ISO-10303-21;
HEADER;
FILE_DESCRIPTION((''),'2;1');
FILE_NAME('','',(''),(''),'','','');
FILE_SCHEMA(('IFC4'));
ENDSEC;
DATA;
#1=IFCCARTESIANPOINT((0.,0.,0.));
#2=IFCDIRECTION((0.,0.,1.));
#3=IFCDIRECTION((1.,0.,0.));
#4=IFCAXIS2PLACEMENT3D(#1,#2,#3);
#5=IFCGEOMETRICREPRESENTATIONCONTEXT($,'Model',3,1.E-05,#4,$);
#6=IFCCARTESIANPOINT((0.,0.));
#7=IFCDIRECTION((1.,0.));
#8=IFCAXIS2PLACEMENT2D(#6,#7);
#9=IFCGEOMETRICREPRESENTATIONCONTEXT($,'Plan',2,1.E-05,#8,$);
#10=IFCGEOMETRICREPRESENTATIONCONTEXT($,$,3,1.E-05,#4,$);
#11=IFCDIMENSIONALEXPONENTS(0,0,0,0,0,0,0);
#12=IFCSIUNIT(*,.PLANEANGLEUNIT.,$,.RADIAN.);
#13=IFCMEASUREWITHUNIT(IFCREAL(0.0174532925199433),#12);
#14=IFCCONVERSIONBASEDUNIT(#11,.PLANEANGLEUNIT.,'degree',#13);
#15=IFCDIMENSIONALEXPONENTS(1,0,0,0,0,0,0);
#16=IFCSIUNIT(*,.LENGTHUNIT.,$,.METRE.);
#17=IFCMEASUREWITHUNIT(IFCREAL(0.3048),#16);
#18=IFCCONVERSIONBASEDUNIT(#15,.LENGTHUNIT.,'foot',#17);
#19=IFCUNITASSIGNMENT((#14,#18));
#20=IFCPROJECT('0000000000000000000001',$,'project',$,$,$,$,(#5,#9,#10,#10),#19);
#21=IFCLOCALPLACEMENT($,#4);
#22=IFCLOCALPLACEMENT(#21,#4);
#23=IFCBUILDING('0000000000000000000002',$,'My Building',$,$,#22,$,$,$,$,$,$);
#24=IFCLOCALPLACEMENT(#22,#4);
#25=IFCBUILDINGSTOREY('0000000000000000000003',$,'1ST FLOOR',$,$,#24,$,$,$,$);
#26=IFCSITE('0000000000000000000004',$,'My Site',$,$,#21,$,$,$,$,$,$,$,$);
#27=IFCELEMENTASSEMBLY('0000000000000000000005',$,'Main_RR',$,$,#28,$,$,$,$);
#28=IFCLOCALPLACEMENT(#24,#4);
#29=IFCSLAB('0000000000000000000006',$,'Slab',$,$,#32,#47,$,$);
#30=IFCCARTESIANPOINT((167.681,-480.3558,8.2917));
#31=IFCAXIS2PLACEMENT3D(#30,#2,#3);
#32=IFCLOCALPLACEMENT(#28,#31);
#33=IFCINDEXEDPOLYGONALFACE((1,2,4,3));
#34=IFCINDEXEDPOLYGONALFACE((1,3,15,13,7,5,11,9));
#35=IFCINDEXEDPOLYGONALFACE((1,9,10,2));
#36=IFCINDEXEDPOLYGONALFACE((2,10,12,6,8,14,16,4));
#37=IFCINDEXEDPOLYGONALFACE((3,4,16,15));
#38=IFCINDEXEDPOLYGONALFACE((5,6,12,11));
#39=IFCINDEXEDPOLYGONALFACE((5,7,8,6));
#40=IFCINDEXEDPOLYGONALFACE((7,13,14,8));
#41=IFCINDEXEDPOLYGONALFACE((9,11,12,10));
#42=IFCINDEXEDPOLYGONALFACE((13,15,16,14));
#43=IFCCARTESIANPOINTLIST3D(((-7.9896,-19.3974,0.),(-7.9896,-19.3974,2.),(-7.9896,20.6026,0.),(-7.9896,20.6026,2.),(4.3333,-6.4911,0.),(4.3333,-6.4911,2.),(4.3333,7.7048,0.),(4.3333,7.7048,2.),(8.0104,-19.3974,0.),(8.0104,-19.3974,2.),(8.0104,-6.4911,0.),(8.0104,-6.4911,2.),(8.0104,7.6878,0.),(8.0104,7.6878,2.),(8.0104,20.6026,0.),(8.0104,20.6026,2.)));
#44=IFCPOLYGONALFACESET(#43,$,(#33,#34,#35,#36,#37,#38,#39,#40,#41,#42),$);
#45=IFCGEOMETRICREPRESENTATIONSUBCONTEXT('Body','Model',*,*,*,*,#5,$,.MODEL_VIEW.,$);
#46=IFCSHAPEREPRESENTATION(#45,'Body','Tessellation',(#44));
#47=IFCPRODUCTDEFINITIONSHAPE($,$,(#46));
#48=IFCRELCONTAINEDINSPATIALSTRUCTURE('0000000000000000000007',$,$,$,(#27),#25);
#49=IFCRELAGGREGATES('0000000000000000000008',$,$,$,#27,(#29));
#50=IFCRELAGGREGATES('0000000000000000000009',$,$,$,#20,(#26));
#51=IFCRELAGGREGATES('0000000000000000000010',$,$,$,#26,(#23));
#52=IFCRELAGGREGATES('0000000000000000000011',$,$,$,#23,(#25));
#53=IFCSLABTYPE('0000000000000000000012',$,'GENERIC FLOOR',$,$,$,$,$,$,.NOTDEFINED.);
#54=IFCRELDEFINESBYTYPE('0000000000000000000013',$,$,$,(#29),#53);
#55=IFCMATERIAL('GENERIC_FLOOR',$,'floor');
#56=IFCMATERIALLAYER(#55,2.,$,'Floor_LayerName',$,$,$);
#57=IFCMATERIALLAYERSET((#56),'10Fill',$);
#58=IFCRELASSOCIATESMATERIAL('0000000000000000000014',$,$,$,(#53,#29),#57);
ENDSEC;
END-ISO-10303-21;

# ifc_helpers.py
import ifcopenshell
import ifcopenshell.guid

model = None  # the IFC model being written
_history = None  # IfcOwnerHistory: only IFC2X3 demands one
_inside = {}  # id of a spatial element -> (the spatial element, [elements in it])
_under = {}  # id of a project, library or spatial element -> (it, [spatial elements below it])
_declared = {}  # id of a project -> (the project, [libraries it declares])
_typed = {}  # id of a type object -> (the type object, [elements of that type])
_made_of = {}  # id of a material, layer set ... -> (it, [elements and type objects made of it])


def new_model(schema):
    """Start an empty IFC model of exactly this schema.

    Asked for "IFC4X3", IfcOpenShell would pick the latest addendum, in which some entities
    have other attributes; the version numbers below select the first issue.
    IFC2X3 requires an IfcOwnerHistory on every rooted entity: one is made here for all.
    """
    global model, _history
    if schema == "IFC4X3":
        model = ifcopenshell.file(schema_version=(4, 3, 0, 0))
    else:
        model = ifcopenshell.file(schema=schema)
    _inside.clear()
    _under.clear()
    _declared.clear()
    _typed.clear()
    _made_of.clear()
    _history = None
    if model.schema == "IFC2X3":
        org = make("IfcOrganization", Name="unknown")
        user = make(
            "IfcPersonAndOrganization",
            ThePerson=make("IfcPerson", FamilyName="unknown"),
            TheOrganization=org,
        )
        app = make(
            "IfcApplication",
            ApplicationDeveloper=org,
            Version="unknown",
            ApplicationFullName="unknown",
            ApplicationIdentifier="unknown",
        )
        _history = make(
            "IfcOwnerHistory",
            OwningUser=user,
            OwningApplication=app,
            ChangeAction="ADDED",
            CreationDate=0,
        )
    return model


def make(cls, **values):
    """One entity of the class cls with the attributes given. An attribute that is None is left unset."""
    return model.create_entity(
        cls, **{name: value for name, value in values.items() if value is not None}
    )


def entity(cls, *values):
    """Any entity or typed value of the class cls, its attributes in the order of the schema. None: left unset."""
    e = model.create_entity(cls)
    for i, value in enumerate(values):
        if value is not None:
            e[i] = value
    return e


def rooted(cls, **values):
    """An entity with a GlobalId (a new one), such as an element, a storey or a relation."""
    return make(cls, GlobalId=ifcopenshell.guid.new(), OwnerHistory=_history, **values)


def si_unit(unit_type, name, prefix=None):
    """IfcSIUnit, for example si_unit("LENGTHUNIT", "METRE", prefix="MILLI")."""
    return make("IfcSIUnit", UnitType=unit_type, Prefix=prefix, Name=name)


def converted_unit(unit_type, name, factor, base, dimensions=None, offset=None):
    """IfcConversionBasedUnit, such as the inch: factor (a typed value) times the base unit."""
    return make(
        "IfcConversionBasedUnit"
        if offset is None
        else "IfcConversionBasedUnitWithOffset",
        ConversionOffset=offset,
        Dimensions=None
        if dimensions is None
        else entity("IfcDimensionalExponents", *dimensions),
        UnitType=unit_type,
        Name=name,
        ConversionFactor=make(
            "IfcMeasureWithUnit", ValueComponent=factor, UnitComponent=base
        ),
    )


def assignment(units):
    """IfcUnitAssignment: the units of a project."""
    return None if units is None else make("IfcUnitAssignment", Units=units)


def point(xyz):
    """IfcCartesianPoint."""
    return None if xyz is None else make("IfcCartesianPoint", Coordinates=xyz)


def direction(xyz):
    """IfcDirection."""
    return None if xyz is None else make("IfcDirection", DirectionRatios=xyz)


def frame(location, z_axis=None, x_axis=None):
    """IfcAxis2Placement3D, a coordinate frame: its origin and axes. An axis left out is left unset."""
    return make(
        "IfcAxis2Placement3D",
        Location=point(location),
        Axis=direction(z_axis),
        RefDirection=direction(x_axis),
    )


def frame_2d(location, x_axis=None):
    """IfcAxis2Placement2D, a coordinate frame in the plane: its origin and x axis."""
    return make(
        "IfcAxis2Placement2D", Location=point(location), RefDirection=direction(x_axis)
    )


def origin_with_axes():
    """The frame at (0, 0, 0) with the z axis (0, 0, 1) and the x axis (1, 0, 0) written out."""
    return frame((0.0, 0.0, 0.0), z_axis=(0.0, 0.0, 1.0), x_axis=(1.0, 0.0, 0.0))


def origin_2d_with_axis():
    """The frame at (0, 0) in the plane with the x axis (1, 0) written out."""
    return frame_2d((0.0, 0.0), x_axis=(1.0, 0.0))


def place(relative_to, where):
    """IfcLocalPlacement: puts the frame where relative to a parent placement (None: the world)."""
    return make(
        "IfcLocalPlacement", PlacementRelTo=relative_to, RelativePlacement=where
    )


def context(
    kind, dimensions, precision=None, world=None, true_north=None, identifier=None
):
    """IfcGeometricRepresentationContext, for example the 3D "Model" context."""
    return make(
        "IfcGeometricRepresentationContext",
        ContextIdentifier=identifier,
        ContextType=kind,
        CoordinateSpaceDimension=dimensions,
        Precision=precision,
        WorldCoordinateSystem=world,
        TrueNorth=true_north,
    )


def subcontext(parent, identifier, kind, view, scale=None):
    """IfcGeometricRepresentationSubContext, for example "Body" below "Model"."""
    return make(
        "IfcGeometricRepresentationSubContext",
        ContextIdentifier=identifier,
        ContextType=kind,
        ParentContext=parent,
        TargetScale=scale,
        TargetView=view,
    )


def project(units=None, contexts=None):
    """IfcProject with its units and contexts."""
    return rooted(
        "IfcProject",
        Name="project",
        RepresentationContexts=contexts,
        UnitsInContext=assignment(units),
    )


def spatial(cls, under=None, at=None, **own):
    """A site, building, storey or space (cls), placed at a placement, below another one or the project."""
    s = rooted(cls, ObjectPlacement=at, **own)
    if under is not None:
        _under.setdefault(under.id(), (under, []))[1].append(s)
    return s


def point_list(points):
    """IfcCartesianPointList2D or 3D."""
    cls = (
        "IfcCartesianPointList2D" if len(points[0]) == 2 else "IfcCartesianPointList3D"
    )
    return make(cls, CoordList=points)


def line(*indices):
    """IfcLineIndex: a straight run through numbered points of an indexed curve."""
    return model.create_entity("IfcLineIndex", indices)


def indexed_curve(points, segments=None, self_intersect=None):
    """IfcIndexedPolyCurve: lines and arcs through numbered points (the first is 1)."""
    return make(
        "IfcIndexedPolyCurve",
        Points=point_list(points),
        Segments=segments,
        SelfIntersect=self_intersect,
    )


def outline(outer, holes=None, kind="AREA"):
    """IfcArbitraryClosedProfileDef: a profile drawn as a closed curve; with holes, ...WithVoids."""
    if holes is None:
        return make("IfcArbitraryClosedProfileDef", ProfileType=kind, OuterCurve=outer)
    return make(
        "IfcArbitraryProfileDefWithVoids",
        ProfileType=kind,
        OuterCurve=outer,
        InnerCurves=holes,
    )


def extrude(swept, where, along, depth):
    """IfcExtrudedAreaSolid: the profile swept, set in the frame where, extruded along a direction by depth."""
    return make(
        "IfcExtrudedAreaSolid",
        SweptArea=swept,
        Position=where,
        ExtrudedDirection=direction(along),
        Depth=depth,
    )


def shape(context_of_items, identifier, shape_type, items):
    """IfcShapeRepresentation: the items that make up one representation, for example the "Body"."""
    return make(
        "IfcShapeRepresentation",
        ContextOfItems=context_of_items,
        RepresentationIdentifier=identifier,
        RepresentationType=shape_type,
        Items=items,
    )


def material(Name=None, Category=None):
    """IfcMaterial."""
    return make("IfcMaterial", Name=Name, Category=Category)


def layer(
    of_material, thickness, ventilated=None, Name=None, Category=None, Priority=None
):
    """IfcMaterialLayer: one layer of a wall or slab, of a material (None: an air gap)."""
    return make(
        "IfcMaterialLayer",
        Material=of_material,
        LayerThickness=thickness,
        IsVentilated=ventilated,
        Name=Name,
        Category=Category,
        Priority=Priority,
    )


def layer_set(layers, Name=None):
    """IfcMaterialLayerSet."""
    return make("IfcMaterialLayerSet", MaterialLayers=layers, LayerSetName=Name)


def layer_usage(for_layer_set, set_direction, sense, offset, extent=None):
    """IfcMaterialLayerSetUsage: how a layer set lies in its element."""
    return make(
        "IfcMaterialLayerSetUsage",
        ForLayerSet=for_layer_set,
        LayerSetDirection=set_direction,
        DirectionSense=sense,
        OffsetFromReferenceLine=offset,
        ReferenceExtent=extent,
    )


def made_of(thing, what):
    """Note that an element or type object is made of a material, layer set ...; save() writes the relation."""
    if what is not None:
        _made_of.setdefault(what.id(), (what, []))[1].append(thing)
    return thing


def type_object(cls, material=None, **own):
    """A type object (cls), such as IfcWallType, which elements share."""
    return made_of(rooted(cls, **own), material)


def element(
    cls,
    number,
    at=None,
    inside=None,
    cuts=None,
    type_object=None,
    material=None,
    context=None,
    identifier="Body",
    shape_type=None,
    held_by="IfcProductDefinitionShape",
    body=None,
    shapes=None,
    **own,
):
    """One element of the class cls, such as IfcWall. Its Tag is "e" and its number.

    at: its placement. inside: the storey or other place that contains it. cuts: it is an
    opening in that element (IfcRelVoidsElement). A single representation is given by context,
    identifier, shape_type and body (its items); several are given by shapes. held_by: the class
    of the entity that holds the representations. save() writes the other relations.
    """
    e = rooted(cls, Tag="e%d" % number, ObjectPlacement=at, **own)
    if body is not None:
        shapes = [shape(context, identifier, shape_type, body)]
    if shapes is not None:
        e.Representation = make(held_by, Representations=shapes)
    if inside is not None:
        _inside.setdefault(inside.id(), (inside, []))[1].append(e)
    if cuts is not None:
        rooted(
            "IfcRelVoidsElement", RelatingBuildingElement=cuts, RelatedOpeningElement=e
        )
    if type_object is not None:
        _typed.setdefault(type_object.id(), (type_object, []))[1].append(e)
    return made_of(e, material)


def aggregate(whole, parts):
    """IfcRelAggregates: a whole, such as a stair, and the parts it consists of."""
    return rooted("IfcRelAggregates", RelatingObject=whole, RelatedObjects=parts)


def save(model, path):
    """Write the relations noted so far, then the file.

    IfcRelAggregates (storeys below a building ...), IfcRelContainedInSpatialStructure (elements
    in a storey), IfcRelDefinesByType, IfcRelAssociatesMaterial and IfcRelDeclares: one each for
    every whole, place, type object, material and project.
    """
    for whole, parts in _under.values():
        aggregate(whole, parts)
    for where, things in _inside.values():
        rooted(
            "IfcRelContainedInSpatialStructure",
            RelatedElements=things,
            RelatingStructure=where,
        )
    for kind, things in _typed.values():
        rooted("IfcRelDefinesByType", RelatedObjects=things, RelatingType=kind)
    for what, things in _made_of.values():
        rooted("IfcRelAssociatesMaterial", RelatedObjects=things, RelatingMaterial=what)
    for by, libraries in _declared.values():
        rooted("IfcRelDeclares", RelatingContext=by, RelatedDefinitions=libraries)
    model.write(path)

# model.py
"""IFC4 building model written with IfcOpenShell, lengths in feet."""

from ifc_helpers import new_model, entity, si_unit, converted_unit, frame, origin_with_axes, origin_2d_with_axis, place, context, subcontext, project, spatial, line, indexed_curve, outline, extrude, material, layer, layer_set, layer_usage, type_object, element, aggregate, save


model = new_model("IFC4")

# Units and contexts
model_context = context("Model", 3, precision=1e-05, world=origin_with_axes())
plan_context = context("Plan", 2, precision=1e-05, world=origin_2d_with_axis())
context_of_model = context(None, 3, precision=1e-05, world=origin_with_axes())
body_context_1 = subcontext(model_context, "Body", "Model", "MODEL_VIEW")
ifc_project = project(units=[converted_unit("PLANEANGLEUNIT", "degree", entity("IfcReal", 0.0174532925199433), si_unit("PLANEANGLEUNIT", "RADIAN"), dimensions=[0, 0, 0, 0, 0, 0, 0]), converted_unit("LENGTHUNIT", "foot", entity("IfcReal", 0.3048), si_unit("LENGTHUNIT", "METRE"), dimensions=[1, 0, 0, 0, 0, 0, 0])], contexts=[model_context, plan_context, context_of_model, context_of_model])

# Site, building, storey
site_placement = place(None, origin_with_axes())
site = spatial("IfcSite", under=ifc_project, at=site_placement, Name="My Site")
building_placement = place(site_placement, origin_with_axes())
building = spatial("IfcBuilding", under=site, at=building_placement, Name="My Building")
storey_placement = place(building_placement, origin_with_axes())
storey = spatial("IfcBuildingStorey", under=building, at=storey_placement, Name="1ST FLOOR")

# Element assembly, slab
assembly_1_placement = place(storey_placement, origin_with_axes())
assembly_1 = element("IfcElementAssembly", 1, at=assembly_1_placement, inside=storey, Name="Main_RR")
ifc_material_1 = material(Name="GENERIC_FLOOR", Category="floor")
ifc_layer_1 = layer(ifc_material_1, 2.0, Name="Floor_LayerName")
ifc_layer_set_1 = layer_set([ifc_layer_1], Name="10Fill")
ifc_layer_usage_1 = layer_usage(ifc_layer_set_1, "AXIS3", "POSITIVE", 0.0)
slab_type = type_object("IfcSlabType", Name="GENERIC FLOOR", PredefinedType="NOTDEFINED", material=ifc_layer_set_1)
slab_placement = place(assembly_1_placement, frame((167.681, -480.3558, 8.2917), z_axis=(0.0, 0.0, 1.0), x_axis=(1.0, 0.0, 0.0)))
slab = element("IfcSlab", 2, at=slab_placement, type_object=slab_type, material=ifc_layer_usage_1, Name="Slab", context=body_context_1, shape_type="SweptSolid", body=[
    extrude(outline(indexed_curve([(-7.9896, -19.3974), (-7.9896, 20.6026), (8.0104, 20.6026), (8.0104, 7.6878), (4.3333, 7.7048), (4.3333, -6.4911), (8.0104, -6.4911), (8.0104, -19.3974)], segments=[line(5, 6), line(6, 7), line(7, 8), line(8, 1), line(1, 2), line(2, 3), line(3, 4), line(4, 5)], self_intersect=False)), None, (0.0, 0.0, 1.0), 2.0),
])

aggregate(assembly_1, [slab])

save(model, "model.ifc")
